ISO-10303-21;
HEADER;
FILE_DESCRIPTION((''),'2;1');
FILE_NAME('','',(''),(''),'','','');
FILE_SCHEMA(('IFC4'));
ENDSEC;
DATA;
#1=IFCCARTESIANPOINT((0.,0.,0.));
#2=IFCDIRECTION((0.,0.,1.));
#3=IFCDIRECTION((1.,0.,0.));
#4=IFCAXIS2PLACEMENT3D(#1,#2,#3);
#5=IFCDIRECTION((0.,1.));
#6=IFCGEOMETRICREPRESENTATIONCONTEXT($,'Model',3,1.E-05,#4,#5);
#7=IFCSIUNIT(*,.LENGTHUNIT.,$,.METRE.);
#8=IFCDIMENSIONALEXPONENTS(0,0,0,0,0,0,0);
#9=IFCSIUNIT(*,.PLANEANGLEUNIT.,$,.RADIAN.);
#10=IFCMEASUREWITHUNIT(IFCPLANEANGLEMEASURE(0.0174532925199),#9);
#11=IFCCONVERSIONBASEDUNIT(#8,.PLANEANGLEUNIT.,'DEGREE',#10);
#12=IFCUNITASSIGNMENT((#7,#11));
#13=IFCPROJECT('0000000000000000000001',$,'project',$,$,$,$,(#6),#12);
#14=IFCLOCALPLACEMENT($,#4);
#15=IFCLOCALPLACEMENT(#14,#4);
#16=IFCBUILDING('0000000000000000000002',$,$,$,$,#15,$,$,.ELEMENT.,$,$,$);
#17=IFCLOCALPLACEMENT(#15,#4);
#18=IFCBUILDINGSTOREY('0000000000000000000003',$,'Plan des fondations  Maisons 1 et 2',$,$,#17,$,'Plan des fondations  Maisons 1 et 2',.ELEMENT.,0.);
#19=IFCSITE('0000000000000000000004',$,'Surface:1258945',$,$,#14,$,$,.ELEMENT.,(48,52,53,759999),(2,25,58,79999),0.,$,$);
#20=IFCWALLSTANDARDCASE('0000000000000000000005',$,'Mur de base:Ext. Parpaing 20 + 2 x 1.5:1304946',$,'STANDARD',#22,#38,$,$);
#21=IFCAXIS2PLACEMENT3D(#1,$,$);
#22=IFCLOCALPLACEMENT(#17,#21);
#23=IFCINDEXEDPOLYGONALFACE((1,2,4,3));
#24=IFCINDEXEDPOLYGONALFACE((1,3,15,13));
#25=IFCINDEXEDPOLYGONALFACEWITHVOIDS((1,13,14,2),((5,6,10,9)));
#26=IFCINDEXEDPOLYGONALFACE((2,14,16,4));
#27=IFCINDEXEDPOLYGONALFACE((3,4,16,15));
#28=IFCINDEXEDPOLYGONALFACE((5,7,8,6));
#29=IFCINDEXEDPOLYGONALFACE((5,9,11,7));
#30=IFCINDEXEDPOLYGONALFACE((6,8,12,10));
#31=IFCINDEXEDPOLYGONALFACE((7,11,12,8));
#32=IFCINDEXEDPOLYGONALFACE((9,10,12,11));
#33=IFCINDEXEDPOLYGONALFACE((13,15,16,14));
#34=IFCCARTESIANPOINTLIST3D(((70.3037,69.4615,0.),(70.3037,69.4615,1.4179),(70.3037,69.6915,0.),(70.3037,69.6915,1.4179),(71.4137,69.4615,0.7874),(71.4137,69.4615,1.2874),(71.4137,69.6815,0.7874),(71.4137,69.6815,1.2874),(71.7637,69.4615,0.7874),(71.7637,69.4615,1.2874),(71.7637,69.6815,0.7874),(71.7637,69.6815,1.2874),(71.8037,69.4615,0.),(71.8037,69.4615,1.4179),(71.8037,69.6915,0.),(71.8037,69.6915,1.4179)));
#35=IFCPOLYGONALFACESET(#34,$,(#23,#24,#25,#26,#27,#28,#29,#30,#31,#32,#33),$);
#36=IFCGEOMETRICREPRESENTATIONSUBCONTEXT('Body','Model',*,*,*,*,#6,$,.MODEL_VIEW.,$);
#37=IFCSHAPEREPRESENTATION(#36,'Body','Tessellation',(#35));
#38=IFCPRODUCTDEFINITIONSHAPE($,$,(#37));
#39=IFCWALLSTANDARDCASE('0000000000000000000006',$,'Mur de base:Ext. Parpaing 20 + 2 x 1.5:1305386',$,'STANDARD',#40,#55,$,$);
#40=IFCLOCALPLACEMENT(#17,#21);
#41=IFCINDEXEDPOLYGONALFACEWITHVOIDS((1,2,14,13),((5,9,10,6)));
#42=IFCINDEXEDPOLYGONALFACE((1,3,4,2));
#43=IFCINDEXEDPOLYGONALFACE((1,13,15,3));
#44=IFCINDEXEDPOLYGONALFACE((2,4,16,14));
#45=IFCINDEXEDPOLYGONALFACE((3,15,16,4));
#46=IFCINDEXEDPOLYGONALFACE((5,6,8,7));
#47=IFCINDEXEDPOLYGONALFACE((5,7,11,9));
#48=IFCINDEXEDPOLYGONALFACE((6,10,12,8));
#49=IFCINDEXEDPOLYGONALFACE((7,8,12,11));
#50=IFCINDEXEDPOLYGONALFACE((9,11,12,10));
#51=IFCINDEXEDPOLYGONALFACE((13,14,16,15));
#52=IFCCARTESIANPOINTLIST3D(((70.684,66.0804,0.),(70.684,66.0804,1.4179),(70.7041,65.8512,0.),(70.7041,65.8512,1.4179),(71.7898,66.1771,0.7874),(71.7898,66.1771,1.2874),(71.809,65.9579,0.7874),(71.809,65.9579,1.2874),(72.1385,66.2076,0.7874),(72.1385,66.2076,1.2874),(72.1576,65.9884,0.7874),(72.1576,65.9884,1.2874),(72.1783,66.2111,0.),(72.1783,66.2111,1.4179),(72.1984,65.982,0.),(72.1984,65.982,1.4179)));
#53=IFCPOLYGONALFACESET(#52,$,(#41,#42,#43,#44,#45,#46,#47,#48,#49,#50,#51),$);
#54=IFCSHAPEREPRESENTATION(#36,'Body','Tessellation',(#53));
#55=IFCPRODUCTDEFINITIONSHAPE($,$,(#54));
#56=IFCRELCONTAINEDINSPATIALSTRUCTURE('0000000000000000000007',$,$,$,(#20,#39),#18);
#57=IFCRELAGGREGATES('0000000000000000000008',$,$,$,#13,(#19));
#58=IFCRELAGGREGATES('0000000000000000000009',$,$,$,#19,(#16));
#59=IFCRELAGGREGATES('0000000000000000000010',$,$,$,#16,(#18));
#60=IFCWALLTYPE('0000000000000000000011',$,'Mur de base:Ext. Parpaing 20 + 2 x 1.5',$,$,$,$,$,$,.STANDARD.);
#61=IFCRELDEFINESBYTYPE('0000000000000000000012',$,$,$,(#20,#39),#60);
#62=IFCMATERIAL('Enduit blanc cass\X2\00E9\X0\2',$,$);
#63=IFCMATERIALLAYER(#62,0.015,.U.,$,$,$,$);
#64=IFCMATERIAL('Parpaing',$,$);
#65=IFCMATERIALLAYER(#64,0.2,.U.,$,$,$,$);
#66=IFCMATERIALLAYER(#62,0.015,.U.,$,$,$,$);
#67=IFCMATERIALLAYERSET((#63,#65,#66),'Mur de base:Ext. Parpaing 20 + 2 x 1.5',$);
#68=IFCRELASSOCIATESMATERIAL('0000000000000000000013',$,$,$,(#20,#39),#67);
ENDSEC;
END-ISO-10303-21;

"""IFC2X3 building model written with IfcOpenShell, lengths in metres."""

from ifc_helpers import new_model, entity, si_unit, converted_unit, direction, frame, origin_with_axes, origin_2d_with_axis, place, context, subcontext, project, spatial, polyline, rectangle, outline, extrude, material, layer, layer_set, layer_usage, type_object, element, save


model = new_model("IFC2X3")

# Units and contexts
model_context = context("Model", 3, precision=1e-05, world=origin_with_axes(), true_north=direction((0.0, 1.0)))
body_context = subcontext(model_context, "Body", "Model", "MODEL_VIEW")
ifc_project = project(units=[si_unit("LENGTHUNIT", "METRE"), converted_unit("PLANEANGLEUNIT", "DEGREE", entity("IfcPlaneAngleMeasure", 0.0174532925199), si_unit("PLANEANGLEUNIT", "RADIAN"), dimensions=[0, 0, 0, 0, 0, 0, 0])], contexts=[model_context])

# Site, building, storey
site_placement = place(None, origin_with_axes())
site = spatial("IfcSite", under=ifc_project, at=site_placement, Name="Surface:1258945", CompositionType="ELEMENT", RefLatitude=(48, 52, 53, 759999), RefLongitude=(2, 25, 58, 79999), RefElevation=0.0)
building_placement = place(site_placement, origin_with_axes())
building = spatial("IfcBuilding", under=site, at=building_placement, CompositionType="ELEMENT")
storey_placement = place(building_placement, origin_with_axes())
storey = spatial("IfcBuildingStorey", under=building, at=storey_placement, Name="Plan des fondations  Maisons 1 et 2", LongName="Plan des fondations  Maisons 1 et 2", CompositionType="ELEMENT", Elevation=0.0)

# Shared definitions
ifc_material_1 = material(Name="Enduit blanc cassé2")
ifc_material_2 = material(Name="Parpaing")

# Walls, openings
ifc_layer_1 = layer(ifc_material_1, 0.015, ventilated="UNKNOWN")
ifc_layer_2 = layer(ifc_material_2, 0.2, ventilated="UNKNOWN")
ifc_layer_3 = layer(ifc_material_1, 0.015, ventilated="UNKNOWN")
ifc_layer_set_1 = layer_set([ifc_layer_1, ifc_layer_2, ifc_layer_3], Name="Mur de base:Ext. Parpaing 20 + 2 x 1.5")
wall_type_1 = type_object("IfcWallType", Name="Mur de base:Ext. Parpaing 20 + 2 x 1.5", PredefinedType="STANDARD")
ifc_layer_usage_1 = layer_usage(ifc_layer_set_1, "AXIS2", "POSITIVE", -0.115)
wall_1_placement = place(storey_placement, frame((70.3037, 69.5765, 0.0), z_axis=(0.0, 0.0, 1.0), x_axis=(1.0, 0.0, 0.0)))
wall_1 = element("IfcWallStandardCase", 1, at=wall_1_placement, inside=storey, type_object=wall_type_1, material=ifc_layer_usage_1, Name="Mur de base:Ext. Parpaing 20 + 2 x 1.5:1304946", ObjectType="STANDARD", context=body_context, shape_type="SweptSolid", body=[
    extrude(outline(polyline([(0.0, -0.115), (1.5, -0.115), (1.5, 0.115), (0.0, 0.115), (0.0, -0.115)])), origin_with_axes(), (0.0, 0.0, 1.0), 1.4179),
])
opening_1_placement = place(wall_1_placement, frame((-70.3037, -69.5765, 0.0), z_axis=(0.0, 0.0, 1.0), x_axis=(1.0, 0.0, 0.0)))
element("IfcOpeningElement", 2, at=opening_1_placement, cuts=wall_1, context=body_context, shape_type="SweptSolid", body=[
    extrude(rectangle(XDim=0.5, YDim=0.35, at=origin_2d_with_axis()), frame((71.5887, 69.4615, 1.0374), z_axis=(0.0, 1.0, 0.0), x_axis=(0.0, 0.0, -1.0)), (0.0, 0.0, 1.0), 0.22),
])
ifc_layer_usage_2 = layer_usage(ifc_layer_set_1, "AXIS2", "POSITIVE", -0.115)
wall_2_placement = place(storey_placement, frame((70.694, 65.9658, 0.0), z_axis=(0.0, 0.0, 1.0), x_axis=(0.996195, 0.087156, 0.0)))
wall_2 = element("IfcWallStandardCase", 3, at=wall_2_placement, inside=storey, type_object=wall_type_1, material=ifc_layer_usage_2, Name="Mur de base:Ext. Parpaing 20 + 2 x 1.5:1305386", ObjectType="STANDARD", context=body_context, shape_type="SweptSolid", body=[
    extrude(outline(polyline([(0.0, -0.115), (1.5, -0.115), (1.5, 0.115), (0.0, 0.115), (0.0, -0.115)])), origin_with_axes(), (0.0, 0.0, 1.0), 1.4179),
])
opening_2_placement = place(wall_2_placement, frame((-76.1743, -59.5534, 0.0), z_axis=(0.0, 0.0, 1.0), x_axis=(0.996195, -0.087156, 0.0)))
element("IfcOpeningElement", 4, at=opening_2_placement, cuts=wall_2, context=body_context, shape_type="SweptSolid", body=[
    extrude(rectangle(XDim=0.5, YDim=0.35, at=origin_2d_with_axis()), frame((71.9833, 65.9732, 1.0374), z_axis=(-0.087156, 0.996195, 0.0), x_axis=(0.0, 0.0, -1.0)), (0.0, 0.0, 1.0), 0.22),
])

save(model, "model.ifc")
